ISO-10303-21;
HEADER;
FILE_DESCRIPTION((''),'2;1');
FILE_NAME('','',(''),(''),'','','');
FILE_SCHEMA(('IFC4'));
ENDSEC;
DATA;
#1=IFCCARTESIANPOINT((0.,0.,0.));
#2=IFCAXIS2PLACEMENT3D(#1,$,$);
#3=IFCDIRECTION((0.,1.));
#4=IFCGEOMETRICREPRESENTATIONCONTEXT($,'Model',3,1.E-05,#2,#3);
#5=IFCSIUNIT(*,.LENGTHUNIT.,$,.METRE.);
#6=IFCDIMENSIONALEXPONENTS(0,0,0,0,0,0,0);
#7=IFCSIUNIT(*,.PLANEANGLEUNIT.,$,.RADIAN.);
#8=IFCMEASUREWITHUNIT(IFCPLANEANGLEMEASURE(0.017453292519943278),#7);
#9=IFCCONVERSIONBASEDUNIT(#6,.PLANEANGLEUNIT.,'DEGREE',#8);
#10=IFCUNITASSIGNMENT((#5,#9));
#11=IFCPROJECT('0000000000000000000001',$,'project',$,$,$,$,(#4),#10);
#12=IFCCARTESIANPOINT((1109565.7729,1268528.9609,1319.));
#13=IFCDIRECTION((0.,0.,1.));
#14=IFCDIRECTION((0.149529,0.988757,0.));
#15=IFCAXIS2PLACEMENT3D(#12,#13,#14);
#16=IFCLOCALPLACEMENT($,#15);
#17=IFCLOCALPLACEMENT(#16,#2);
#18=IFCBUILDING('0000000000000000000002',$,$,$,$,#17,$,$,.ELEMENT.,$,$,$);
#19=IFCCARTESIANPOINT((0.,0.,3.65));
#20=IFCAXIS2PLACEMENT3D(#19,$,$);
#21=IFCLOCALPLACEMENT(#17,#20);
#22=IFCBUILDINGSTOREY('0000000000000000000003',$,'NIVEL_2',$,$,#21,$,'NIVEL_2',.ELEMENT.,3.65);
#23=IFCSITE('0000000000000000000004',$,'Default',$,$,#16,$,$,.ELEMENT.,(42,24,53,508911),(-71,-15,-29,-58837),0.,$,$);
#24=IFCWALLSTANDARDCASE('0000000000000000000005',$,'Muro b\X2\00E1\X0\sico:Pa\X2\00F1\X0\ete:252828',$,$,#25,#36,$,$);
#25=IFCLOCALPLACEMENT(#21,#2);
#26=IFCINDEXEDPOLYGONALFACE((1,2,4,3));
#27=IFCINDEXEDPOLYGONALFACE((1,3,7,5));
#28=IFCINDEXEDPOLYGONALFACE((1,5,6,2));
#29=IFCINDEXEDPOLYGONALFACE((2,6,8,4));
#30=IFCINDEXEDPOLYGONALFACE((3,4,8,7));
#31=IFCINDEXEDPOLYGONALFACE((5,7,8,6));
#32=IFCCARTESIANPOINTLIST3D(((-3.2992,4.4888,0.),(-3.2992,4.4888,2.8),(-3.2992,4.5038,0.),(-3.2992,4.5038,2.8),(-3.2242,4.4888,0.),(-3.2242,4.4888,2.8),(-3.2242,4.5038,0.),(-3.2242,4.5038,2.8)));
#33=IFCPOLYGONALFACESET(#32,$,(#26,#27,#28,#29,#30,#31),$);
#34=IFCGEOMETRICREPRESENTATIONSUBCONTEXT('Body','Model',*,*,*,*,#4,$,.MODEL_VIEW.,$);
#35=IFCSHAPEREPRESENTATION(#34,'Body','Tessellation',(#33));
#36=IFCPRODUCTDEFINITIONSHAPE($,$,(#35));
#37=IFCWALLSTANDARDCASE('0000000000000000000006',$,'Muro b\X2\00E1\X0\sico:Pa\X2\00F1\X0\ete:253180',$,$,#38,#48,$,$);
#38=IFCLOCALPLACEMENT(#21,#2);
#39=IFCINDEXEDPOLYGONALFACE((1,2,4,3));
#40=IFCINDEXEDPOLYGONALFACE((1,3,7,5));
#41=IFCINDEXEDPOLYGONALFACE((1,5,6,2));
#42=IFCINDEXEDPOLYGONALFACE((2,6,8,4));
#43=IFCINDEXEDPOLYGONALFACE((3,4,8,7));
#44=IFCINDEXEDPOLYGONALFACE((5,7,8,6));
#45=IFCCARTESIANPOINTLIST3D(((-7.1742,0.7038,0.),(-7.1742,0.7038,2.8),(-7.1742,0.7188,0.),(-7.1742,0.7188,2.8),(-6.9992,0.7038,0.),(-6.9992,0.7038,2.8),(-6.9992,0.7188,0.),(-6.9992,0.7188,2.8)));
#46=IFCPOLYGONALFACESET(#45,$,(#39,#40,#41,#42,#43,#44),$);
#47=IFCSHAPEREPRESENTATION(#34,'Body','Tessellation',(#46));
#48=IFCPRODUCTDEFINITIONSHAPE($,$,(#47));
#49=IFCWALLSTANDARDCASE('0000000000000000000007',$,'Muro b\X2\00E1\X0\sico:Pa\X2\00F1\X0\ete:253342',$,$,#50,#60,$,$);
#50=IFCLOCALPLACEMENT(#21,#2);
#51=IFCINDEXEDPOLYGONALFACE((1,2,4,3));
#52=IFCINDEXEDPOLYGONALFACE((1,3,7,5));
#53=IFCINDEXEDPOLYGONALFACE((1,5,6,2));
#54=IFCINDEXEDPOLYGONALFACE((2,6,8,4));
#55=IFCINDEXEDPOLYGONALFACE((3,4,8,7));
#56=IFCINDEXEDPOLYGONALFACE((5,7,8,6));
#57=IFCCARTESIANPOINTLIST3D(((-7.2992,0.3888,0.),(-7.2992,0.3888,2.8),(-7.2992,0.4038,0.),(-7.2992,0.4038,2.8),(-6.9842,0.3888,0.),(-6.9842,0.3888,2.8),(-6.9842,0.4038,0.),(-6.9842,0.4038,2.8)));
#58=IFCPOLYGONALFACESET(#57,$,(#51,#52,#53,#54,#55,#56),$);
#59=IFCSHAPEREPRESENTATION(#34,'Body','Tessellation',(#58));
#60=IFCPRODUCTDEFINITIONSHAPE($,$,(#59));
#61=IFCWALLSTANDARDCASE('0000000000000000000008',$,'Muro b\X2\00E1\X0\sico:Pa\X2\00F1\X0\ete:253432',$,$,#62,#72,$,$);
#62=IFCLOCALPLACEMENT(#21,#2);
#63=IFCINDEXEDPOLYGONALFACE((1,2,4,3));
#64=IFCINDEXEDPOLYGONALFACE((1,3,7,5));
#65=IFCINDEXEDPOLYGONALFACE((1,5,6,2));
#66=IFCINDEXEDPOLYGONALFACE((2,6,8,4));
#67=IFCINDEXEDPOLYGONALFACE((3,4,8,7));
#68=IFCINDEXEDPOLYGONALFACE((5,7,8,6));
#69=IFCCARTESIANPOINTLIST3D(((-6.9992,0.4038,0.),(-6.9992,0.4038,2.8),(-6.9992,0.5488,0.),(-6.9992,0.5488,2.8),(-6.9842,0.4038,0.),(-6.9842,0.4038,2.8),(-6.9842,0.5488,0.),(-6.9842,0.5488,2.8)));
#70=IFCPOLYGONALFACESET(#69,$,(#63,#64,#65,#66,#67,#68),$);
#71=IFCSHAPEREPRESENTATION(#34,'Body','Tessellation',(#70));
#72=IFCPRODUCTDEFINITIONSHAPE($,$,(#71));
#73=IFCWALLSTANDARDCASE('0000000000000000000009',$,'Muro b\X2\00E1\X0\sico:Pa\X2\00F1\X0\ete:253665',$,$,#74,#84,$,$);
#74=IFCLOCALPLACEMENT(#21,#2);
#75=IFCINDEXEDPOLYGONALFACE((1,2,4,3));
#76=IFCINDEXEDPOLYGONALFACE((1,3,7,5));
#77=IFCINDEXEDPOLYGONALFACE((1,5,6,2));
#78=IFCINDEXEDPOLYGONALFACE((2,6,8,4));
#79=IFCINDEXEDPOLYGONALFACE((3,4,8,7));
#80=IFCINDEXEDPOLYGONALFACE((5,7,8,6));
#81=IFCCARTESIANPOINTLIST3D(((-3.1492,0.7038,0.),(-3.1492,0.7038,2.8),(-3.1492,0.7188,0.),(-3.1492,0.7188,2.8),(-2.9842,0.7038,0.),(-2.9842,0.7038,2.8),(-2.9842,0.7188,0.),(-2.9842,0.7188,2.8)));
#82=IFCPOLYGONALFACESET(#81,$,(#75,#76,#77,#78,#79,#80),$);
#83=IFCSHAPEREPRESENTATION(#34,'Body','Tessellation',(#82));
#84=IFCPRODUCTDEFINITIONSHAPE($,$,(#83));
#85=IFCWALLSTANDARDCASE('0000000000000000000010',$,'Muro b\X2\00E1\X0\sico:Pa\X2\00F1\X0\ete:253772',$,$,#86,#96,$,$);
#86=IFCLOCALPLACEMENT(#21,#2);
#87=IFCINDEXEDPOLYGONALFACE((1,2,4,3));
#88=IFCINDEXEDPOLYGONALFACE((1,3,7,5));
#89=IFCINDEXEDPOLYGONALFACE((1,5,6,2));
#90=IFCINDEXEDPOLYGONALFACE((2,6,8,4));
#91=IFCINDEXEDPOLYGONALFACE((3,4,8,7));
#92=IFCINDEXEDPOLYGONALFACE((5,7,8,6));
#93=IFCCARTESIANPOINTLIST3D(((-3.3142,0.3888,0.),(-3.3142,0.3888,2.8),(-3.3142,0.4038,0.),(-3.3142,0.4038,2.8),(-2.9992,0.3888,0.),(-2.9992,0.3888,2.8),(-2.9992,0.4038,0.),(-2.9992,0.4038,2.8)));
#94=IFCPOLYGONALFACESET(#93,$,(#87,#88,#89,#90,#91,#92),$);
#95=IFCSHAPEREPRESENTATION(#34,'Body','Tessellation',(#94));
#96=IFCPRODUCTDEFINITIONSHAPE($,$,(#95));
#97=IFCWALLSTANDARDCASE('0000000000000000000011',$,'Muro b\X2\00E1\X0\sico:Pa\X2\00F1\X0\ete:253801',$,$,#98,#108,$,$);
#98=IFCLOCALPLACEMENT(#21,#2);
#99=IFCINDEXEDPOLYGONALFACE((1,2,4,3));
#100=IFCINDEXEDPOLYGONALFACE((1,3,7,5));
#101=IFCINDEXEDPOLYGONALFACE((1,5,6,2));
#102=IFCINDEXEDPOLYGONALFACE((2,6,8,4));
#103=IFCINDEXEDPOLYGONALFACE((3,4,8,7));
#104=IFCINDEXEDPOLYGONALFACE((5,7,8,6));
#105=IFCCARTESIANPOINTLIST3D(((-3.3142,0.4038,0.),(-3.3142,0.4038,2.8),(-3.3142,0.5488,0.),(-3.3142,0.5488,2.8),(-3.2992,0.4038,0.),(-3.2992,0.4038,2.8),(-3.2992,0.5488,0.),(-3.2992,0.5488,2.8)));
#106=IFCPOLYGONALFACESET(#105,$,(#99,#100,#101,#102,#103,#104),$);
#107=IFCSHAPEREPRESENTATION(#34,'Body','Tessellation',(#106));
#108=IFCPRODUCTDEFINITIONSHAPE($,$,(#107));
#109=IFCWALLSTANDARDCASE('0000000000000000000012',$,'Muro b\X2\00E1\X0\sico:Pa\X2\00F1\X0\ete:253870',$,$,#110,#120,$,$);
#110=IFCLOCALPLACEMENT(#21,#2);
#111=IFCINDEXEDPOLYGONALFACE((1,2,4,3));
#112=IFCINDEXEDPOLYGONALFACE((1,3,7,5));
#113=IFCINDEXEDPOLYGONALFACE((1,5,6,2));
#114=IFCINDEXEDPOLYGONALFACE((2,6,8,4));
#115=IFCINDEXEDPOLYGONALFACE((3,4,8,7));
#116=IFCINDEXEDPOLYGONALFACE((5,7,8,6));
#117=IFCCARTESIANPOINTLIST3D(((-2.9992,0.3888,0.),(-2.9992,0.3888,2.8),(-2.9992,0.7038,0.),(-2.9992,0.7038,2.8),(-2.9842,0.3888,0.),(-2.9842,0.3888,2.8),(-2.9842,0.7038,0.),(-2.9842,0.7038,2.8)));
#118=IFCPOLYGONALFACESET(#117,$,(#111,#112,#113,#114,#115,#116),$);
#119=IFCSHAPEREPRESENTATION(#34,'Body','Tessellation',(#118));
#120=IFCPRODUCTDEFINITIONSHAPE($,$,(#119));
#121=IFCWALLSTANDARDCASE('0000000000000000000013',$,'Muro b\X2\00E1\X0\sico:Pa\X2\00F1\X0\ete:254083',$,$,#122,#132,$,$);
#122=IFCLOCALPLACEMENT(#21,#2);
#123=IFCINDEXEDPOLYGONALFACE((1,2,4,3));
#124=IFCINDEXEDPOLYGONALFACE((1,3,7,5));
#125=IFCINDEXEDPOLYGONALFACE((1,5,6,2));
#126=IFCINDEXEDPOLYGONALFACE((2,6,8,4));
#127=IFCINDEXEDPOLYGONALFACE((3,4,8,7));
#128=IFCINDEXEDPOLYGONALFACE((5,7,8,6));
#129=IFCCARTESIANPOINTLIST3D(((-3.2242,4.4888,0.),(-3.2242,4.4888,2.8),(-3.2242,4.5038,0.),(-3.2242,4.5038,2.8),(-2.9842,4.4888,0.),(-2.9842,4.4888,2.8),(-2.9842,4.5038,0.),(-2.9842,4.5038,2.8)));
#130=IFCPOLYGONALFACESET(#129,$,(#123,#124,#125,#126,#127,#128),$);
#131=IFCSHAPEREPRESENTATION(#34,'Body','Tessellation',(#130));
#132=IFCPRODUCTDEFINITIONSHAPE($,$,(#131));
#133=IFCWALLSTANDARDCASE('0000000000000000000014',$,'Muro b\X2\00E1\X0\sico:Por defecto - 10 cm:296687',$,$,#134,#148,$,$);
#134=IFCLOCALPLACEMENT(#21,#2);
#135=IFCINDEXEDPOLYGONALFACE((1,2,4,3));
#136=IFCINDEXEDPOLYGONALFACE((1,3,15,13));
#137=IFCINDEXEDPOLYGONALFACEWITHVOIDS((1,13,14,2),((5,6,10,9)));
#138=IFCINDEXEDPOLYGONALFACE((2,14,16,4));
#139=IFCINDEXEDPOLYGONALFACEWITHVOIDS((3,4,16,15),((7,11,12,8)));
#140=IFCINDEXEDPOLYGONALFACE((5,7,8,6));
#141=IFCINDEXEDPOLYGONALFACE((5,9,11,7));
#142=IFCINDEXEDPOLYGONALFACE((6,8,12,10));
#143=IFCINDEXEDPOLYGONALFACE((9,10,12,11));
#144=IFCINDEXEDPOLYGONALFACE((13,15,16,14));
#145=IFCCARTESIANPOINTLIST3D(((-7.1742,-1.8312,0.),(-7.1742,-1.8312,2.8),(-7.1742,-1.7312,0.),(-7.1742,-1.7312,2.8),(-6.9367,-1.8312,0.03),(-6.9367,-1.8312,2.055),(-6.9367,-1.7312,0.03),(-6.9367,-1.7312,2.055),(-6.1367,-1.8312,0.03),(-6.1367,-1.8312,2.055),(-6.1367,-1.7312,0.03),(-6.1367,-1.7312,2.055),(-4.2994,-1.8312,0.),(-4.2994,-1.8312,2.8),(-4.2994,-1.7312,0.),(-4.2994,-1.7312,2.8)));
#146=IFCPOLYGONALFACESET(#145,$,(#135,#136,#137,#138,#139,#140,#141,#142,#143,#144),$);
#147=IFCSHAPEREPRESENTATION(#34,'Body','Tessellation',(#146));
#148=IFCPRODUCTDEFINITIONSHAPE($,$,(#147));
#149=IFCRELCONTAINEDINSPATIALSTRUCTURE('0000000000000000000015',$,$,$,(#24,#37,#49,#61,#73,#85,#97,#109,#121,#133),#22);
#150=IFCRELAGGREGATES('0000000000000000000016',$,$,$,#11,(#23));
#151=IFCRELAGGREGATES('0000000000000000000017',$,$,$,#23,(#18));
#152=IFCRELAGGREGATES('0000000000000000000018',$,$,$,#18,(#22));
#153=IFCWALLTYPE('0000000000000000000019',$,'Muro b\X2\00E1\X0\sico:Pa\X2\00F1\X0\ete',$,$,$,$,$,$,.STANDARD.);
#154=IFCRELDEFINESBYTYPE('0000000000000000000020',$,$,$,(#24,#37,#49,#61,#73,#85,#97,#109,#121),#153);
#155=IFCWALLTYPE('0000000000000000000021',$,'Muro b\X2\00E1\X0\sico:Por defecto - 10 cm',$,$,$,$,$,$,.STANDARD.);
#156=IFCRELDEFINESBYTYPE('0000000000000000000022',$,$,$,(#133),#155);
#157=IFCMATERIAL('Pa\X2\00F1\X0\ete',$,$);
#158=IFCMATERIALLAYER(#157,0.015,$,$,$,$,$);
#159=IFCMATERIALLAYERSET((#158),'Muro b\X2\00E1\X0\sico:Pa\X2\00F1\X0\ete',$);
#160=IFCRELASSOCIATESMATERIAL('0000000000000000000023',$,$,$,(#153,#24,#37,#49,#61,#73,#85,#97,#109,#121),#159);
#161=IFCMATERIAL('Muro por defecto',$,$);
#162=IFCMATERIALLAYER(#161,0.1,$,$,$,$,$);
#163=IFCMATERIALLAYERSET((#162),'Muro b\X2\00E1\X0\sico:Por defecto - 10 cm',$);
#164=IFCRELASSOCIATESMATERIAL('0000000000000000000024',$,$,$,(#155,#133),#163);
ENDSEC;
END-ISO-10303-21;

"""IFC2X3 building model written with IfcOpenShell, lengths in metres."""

from ifc_helpers import new_model, entity, si_unit, converted_unit, direction, frame, frame_2d, origin, place, context, subcontext, project, spatial, rectangle, extrude, material, layer, layer_set, layer_usage, type_object, element, save


model = new_model("IFC2X3")

# Units and contexts
model_context = context("Model", 3, precision=1e-05, world=origin(), true_north=direction((0.0, 1.0)))
body_context = subcontext(model_context, "Body", "Model", "MODEL_VIEW")
ifc_project = project(units=[si_unit("LENGTHUNIT", "METRE"), converted_unit("PLANEANGLEUNIT", "DEGREE", entity("IfcPlaneAngleMeasure", 0.017453292519943278), si_unit("PLANEANGLEUNIT", "RADIAN"), dimensions=[0, 0, 0, 0, 0, 0, 0])], contexts=[model_context])

# Site, building, storey
site_placement = place(None, frame((1109565.7729, 1268528.9609, 1319.0), z_axis=(0.0, 0.0, 1.0), x_axis=(0.149529, 0.988757, 0.0)))
site = spatial("IfcSite", under=ifc_project, at=site_placement, Name="Default", CompositionType="ELEMENT", RefLatitude=(42, 24, 53, 508911), RefLongitude=(-71, -15, -29, -58837), RefElevation=0.0)
building_placement = place(site_placement, origin())
building = spatial("IfcBuilding", under=site, at=building_placement, CompositionType="ELEMENT")
storey_placement = place(building_placement, frame((0.0, 0.0, 3.65)))
storey = spatial("IfcBuildingStorey", under=building, at=storey_placement, Name="NIVEL_2", LongName="NIVEL_2", CompositionType="ELEMENT", Elevation=3.65)

# Shared definitions
ifc_material_1 = material(Name="Pañete")

# Walls
ifc_layer_1 = layer(ifc_material_1, 0.015)
ifc_layer_set_1 = layer_set([ifc_layer_1], Name="Muro básico:Pañete")
wall_type_1 = type_object("IfcWallType", Name="Muro básico:Pañete", PredefinedType="STANDARD", material=ifc_layer_set_1)
ifc_layer_usage_1 = layer_usage(ifc_layer_set_1, "AXIS2", "POSITIVE", -0.0075)
wall_1_placement = place(storey_placement, frame((-3.2992, 4.4963, 0.0)))
element("IfcWallStandardCase", 1, at=wall_1_placement, inside=storey, type_object=wall_type_1, material=ifc_layer_usage_1, Name="Muro básico:Pañete:252828", context=body_context, shape_type="SweptSolid", body=[
    extrude(rectangle(XDim=0.075, YDim=0.015, at=frame_2d((0.0375, 0.0), x_axis=(-1.0, 0.0))), origin(), (0.0, 0.0, 1.0), 2.8),
])
ifc_layer_usage_2 = layer_usage(ifc_layer_set_1, "AXIS2", "NEGATIVE", 0.0075)
wall_2_placement = place(storey_placement, frame((-7.1742, 0.7113, 0.0)))
element("IfcWallStandardCase", 2, at=wall_2_placement, inside=storey, type_object=wall_type_1, material=ifc_layer_usage_2, Name="Muro básico:Pañete:253180", context=body_context, shape_type="SweptSolid", body=[
    extrude(rectangle(XDim=0.175, YDim=0.015, at=frame_2d((0.0875, 0.0), x_axis=(-1.0, 0.0))), origin(), (0.0, 0.0, 1.0), 2.8),
])
ifc_layer_usage_3 = layer_usage(ifc_layer_set_1, "AXIS2", "POSITIVE", -0.0075)
wall_3_placement = place(storey_placement, frame((-7.2992, 0.3963, 0.0)))
element("IfcWallStandardCase", 3, at=wall_3_placement, inside=storey, type_object=wall_type_1, material=ifc_layer_usage_3, Name="Muro básico:Pañete:253342", context=body_context, shape_type="SweptSolid", body=[
    extrude(rectangle(XDim=0.315, YDim=0.015, at=frame_2d((0.1575, 0.0), x_axis=(-1.0, 0.0))), origin(), (0.0, 0.0, 1.0), 2.8),
])
ifc_layer_usage_4 = layer_usage(ifc_layer_set_1, "AXIS2", "POSITIVE", -0.0075)
wall_4_placement = place(storey_placement, frame((-6.9917, 0.4038, 0.0), z_axis=(0.0, 0.0, 1.0), x_axis=(0.0, 1.0, 0.0)))
element("IfcWallStandardCase", 4, at=wall_4_placement, inside=storey, type_object=wall_type_1, material=ifc_layer_usage_4, Name="Muro básico:Pañete:253432", context=body_context, shape_type="SweptSolid", body=[
    extrude(rectangle(XDim=0.145, YDim=0.015, at=frame_2d((0.0725, 0.0), x_axis=(-1.0, 0.0))), origin(), (0.0, 0.0, 1.0), 2.8),
])
ifc_layer_usage_5 = layer_usage(ifc_layer_set_1, "AXIS2", "NEGATIVE", 0.0075)
wall_5_placement = place(storey_placement, frame((-3.1492, 0.7113, 0.0)))
element("IfcWallStandardCase", 5, at=wall_5_placement, inside=storey, type_object=wall_type_1, material=ifc_layer_usage_5, Name="Muro básico:Pañete:253665", context=body_context, shape_type="SweptSolid", body=[
    extrude(rectangle(XDim=0.165, YDim=0.015, at=frame_2d((0.0825, 0.0), x_axis=(-1.0, 0.0))), origin(), (0.0, 0.0, 1.0), 2.8),
])
ifc_layer_usage_6 = layer_usage(ifc_layer_set_1, "AXIS2", "NEGATIVE", 0.0075)
wall_6_placement = place(storey_placement, frame((-2.9992, 0.3963, 0.0), z_axis=(0.0, 0.0, 1.0), x_axis=(-1.0, 0.0, 0.0)))
element("IfcWallStandardCase", 6, at=wall_6_placement, inside=storey, type_object=wall_type_1, material=ifc_layer_usage_6, Name="Muro básico:Pañete:253772", context=body_context, shape_type="SweptSolid", body=[
    extrude(rectangle(XDim=0.315, YDim=0.015, at=frame_2d((0.1575, 0.0), x_axis=(-1.0, 0.0))), origin(), (0.0, 0.0, 1.0), 2.8),
])
ifc_layer_usage_7 = layer_usage(ifc_layer_set_1, "AXIS2", "NEGATIVE", 0.0075)
wall_7_placement = place(storey_placement, frame((-3.3067, 0.4038, 0.0), z_axis=(0.0, 0.0, 1.0), x_axis=(0.0, 1.0, 0.0)))
element("IfcWallStandardCase", 7, at=wall_7_placement, inside=storey, type_object=wall_type_1, material=ifc_layer_usage_7, Name="Muro básico:Pañete:253801", context=body_context, shape_type="SweptSolid", body=[
    extrude(rectangle(XDim=0.145, YDim=0.015, at=frame_2d((0.0725, 0.0), x_axis=(-1.0, 0.0))), origin(), (0.0, 0.0, 1.0), 2.8),
])
ifc_layer_usage_8 = layer_usage(ifc_layer_set_1, "AXIS2", "NEGATIVE", 0.0075)
wall_8_placement = place(storey_placement, frame((-2.9917, 0.7038, 0.0), z_axis=(0.0, 0.0, 1.0), x_axis=(0.0, -1.0, 0.0)))
element("IfcWallStandardCase", 8, at=wall_8_placement, inside=storey, type_object=wall_type_1, material=ifc_layer_usage_8, Name="Muro básico:Pañete:253870", context=body_context, shape_type="SweptSolid", body=[
    extrude(rectangle(XDim=0.315, YDim=0.015, at=frame_2d((0.1575, 0.0), x_axis=(-1.0, 0.0))), origin(), (0.0, 0.0, 1.0), 2.8),
])

# Wall
ifc_layer_usage_9 = layer_usage(ifc_layer_set_1, "AXIS2", "POSITIVE", -0.0075)
wall_9_placement = place(storey_placement, frame((-3.2242, 4.4963, 0.0)))
element("IfcWallStandardCase", 9, at=wall_9_placement, inside=storey, type_object=wall_type_1, material=ifc_layer_usage_9, Name="Muro básico:Pañete:254083", context=body_context, shape_type="SweptSolid", body=[
    extrude(rectangle(XDim=0.24, YDim=0.015, at=frame_2d((0.12, 0.0), x_axis=(-1.0, 0.0))), origin(), (0.0, 0.0, 1.0), 2.8),
])

# Wall, opening
ifc_material_2 = material(Name="Muro por defecto")
ifc_layer_2 = layer(ifc_material_2, 0.1)
ifc_layer_set_2 = layer_set([ifc_layer_2], Name="Muro básico:Por defecto - 10 cm")
ifc_layer_usage_10 = layer_usage(ifc_layer_set_2, "AXIS2", "NEGATIVE", 0.05)
wall_type_2 = type_object("IfcWallType", Name="Muro básico:Por defecto - 10 cm", PredefinedType="STANDARD", material=ifc_layer_set_2)
wall_10_placement = place(storey_placement, frame((-4.2994, -1.7812, 0.0), z_axis=(0.0, 0.0, 1.0), x_axis=(-1.0, 0.0, 0.0)))
wall_10 = element("IfcWallStandardCase", 10, at=wall_10_placement, inside=storey, type_object=wall_type_2, material=ifc_layer_usage_10, Name="Muro básico:Por defecto - 10 cm:296687", context=body_context, shape_type="SweptSolid", body=[
    extrude(rectangle(XDim=2.8749, YDim=0.1, at=frame_2d((1.4374, 0.0), x_axis=(-1.0, 0.0))), origin(), (0.0, 0.0, 1.0), 2.8),
])
opening_1_placement = place(wall_10_placement, frame((1.8374, -0.05, 0.03)))
element("IfcOpeningElement", 11, at=opening_1_placement, cuts=wall_10, ObjectType="Opening", context=body_context, shape_type="SweptSolid", body=[
    extrude(rectangle(XDim=2.025, YDim=0.8, at=frame_2d((1.0125, 0.4), x_axis=(1.0, 0.0))), frame((0.0, 0.0, 0.0), z_axis=(0.0, 1.0, 0.0), x_axis=(0.0, 0.0, 1.0)), (0.0, 0.0, 1.0), 0.1),
])

save(model, "model.ifc")
